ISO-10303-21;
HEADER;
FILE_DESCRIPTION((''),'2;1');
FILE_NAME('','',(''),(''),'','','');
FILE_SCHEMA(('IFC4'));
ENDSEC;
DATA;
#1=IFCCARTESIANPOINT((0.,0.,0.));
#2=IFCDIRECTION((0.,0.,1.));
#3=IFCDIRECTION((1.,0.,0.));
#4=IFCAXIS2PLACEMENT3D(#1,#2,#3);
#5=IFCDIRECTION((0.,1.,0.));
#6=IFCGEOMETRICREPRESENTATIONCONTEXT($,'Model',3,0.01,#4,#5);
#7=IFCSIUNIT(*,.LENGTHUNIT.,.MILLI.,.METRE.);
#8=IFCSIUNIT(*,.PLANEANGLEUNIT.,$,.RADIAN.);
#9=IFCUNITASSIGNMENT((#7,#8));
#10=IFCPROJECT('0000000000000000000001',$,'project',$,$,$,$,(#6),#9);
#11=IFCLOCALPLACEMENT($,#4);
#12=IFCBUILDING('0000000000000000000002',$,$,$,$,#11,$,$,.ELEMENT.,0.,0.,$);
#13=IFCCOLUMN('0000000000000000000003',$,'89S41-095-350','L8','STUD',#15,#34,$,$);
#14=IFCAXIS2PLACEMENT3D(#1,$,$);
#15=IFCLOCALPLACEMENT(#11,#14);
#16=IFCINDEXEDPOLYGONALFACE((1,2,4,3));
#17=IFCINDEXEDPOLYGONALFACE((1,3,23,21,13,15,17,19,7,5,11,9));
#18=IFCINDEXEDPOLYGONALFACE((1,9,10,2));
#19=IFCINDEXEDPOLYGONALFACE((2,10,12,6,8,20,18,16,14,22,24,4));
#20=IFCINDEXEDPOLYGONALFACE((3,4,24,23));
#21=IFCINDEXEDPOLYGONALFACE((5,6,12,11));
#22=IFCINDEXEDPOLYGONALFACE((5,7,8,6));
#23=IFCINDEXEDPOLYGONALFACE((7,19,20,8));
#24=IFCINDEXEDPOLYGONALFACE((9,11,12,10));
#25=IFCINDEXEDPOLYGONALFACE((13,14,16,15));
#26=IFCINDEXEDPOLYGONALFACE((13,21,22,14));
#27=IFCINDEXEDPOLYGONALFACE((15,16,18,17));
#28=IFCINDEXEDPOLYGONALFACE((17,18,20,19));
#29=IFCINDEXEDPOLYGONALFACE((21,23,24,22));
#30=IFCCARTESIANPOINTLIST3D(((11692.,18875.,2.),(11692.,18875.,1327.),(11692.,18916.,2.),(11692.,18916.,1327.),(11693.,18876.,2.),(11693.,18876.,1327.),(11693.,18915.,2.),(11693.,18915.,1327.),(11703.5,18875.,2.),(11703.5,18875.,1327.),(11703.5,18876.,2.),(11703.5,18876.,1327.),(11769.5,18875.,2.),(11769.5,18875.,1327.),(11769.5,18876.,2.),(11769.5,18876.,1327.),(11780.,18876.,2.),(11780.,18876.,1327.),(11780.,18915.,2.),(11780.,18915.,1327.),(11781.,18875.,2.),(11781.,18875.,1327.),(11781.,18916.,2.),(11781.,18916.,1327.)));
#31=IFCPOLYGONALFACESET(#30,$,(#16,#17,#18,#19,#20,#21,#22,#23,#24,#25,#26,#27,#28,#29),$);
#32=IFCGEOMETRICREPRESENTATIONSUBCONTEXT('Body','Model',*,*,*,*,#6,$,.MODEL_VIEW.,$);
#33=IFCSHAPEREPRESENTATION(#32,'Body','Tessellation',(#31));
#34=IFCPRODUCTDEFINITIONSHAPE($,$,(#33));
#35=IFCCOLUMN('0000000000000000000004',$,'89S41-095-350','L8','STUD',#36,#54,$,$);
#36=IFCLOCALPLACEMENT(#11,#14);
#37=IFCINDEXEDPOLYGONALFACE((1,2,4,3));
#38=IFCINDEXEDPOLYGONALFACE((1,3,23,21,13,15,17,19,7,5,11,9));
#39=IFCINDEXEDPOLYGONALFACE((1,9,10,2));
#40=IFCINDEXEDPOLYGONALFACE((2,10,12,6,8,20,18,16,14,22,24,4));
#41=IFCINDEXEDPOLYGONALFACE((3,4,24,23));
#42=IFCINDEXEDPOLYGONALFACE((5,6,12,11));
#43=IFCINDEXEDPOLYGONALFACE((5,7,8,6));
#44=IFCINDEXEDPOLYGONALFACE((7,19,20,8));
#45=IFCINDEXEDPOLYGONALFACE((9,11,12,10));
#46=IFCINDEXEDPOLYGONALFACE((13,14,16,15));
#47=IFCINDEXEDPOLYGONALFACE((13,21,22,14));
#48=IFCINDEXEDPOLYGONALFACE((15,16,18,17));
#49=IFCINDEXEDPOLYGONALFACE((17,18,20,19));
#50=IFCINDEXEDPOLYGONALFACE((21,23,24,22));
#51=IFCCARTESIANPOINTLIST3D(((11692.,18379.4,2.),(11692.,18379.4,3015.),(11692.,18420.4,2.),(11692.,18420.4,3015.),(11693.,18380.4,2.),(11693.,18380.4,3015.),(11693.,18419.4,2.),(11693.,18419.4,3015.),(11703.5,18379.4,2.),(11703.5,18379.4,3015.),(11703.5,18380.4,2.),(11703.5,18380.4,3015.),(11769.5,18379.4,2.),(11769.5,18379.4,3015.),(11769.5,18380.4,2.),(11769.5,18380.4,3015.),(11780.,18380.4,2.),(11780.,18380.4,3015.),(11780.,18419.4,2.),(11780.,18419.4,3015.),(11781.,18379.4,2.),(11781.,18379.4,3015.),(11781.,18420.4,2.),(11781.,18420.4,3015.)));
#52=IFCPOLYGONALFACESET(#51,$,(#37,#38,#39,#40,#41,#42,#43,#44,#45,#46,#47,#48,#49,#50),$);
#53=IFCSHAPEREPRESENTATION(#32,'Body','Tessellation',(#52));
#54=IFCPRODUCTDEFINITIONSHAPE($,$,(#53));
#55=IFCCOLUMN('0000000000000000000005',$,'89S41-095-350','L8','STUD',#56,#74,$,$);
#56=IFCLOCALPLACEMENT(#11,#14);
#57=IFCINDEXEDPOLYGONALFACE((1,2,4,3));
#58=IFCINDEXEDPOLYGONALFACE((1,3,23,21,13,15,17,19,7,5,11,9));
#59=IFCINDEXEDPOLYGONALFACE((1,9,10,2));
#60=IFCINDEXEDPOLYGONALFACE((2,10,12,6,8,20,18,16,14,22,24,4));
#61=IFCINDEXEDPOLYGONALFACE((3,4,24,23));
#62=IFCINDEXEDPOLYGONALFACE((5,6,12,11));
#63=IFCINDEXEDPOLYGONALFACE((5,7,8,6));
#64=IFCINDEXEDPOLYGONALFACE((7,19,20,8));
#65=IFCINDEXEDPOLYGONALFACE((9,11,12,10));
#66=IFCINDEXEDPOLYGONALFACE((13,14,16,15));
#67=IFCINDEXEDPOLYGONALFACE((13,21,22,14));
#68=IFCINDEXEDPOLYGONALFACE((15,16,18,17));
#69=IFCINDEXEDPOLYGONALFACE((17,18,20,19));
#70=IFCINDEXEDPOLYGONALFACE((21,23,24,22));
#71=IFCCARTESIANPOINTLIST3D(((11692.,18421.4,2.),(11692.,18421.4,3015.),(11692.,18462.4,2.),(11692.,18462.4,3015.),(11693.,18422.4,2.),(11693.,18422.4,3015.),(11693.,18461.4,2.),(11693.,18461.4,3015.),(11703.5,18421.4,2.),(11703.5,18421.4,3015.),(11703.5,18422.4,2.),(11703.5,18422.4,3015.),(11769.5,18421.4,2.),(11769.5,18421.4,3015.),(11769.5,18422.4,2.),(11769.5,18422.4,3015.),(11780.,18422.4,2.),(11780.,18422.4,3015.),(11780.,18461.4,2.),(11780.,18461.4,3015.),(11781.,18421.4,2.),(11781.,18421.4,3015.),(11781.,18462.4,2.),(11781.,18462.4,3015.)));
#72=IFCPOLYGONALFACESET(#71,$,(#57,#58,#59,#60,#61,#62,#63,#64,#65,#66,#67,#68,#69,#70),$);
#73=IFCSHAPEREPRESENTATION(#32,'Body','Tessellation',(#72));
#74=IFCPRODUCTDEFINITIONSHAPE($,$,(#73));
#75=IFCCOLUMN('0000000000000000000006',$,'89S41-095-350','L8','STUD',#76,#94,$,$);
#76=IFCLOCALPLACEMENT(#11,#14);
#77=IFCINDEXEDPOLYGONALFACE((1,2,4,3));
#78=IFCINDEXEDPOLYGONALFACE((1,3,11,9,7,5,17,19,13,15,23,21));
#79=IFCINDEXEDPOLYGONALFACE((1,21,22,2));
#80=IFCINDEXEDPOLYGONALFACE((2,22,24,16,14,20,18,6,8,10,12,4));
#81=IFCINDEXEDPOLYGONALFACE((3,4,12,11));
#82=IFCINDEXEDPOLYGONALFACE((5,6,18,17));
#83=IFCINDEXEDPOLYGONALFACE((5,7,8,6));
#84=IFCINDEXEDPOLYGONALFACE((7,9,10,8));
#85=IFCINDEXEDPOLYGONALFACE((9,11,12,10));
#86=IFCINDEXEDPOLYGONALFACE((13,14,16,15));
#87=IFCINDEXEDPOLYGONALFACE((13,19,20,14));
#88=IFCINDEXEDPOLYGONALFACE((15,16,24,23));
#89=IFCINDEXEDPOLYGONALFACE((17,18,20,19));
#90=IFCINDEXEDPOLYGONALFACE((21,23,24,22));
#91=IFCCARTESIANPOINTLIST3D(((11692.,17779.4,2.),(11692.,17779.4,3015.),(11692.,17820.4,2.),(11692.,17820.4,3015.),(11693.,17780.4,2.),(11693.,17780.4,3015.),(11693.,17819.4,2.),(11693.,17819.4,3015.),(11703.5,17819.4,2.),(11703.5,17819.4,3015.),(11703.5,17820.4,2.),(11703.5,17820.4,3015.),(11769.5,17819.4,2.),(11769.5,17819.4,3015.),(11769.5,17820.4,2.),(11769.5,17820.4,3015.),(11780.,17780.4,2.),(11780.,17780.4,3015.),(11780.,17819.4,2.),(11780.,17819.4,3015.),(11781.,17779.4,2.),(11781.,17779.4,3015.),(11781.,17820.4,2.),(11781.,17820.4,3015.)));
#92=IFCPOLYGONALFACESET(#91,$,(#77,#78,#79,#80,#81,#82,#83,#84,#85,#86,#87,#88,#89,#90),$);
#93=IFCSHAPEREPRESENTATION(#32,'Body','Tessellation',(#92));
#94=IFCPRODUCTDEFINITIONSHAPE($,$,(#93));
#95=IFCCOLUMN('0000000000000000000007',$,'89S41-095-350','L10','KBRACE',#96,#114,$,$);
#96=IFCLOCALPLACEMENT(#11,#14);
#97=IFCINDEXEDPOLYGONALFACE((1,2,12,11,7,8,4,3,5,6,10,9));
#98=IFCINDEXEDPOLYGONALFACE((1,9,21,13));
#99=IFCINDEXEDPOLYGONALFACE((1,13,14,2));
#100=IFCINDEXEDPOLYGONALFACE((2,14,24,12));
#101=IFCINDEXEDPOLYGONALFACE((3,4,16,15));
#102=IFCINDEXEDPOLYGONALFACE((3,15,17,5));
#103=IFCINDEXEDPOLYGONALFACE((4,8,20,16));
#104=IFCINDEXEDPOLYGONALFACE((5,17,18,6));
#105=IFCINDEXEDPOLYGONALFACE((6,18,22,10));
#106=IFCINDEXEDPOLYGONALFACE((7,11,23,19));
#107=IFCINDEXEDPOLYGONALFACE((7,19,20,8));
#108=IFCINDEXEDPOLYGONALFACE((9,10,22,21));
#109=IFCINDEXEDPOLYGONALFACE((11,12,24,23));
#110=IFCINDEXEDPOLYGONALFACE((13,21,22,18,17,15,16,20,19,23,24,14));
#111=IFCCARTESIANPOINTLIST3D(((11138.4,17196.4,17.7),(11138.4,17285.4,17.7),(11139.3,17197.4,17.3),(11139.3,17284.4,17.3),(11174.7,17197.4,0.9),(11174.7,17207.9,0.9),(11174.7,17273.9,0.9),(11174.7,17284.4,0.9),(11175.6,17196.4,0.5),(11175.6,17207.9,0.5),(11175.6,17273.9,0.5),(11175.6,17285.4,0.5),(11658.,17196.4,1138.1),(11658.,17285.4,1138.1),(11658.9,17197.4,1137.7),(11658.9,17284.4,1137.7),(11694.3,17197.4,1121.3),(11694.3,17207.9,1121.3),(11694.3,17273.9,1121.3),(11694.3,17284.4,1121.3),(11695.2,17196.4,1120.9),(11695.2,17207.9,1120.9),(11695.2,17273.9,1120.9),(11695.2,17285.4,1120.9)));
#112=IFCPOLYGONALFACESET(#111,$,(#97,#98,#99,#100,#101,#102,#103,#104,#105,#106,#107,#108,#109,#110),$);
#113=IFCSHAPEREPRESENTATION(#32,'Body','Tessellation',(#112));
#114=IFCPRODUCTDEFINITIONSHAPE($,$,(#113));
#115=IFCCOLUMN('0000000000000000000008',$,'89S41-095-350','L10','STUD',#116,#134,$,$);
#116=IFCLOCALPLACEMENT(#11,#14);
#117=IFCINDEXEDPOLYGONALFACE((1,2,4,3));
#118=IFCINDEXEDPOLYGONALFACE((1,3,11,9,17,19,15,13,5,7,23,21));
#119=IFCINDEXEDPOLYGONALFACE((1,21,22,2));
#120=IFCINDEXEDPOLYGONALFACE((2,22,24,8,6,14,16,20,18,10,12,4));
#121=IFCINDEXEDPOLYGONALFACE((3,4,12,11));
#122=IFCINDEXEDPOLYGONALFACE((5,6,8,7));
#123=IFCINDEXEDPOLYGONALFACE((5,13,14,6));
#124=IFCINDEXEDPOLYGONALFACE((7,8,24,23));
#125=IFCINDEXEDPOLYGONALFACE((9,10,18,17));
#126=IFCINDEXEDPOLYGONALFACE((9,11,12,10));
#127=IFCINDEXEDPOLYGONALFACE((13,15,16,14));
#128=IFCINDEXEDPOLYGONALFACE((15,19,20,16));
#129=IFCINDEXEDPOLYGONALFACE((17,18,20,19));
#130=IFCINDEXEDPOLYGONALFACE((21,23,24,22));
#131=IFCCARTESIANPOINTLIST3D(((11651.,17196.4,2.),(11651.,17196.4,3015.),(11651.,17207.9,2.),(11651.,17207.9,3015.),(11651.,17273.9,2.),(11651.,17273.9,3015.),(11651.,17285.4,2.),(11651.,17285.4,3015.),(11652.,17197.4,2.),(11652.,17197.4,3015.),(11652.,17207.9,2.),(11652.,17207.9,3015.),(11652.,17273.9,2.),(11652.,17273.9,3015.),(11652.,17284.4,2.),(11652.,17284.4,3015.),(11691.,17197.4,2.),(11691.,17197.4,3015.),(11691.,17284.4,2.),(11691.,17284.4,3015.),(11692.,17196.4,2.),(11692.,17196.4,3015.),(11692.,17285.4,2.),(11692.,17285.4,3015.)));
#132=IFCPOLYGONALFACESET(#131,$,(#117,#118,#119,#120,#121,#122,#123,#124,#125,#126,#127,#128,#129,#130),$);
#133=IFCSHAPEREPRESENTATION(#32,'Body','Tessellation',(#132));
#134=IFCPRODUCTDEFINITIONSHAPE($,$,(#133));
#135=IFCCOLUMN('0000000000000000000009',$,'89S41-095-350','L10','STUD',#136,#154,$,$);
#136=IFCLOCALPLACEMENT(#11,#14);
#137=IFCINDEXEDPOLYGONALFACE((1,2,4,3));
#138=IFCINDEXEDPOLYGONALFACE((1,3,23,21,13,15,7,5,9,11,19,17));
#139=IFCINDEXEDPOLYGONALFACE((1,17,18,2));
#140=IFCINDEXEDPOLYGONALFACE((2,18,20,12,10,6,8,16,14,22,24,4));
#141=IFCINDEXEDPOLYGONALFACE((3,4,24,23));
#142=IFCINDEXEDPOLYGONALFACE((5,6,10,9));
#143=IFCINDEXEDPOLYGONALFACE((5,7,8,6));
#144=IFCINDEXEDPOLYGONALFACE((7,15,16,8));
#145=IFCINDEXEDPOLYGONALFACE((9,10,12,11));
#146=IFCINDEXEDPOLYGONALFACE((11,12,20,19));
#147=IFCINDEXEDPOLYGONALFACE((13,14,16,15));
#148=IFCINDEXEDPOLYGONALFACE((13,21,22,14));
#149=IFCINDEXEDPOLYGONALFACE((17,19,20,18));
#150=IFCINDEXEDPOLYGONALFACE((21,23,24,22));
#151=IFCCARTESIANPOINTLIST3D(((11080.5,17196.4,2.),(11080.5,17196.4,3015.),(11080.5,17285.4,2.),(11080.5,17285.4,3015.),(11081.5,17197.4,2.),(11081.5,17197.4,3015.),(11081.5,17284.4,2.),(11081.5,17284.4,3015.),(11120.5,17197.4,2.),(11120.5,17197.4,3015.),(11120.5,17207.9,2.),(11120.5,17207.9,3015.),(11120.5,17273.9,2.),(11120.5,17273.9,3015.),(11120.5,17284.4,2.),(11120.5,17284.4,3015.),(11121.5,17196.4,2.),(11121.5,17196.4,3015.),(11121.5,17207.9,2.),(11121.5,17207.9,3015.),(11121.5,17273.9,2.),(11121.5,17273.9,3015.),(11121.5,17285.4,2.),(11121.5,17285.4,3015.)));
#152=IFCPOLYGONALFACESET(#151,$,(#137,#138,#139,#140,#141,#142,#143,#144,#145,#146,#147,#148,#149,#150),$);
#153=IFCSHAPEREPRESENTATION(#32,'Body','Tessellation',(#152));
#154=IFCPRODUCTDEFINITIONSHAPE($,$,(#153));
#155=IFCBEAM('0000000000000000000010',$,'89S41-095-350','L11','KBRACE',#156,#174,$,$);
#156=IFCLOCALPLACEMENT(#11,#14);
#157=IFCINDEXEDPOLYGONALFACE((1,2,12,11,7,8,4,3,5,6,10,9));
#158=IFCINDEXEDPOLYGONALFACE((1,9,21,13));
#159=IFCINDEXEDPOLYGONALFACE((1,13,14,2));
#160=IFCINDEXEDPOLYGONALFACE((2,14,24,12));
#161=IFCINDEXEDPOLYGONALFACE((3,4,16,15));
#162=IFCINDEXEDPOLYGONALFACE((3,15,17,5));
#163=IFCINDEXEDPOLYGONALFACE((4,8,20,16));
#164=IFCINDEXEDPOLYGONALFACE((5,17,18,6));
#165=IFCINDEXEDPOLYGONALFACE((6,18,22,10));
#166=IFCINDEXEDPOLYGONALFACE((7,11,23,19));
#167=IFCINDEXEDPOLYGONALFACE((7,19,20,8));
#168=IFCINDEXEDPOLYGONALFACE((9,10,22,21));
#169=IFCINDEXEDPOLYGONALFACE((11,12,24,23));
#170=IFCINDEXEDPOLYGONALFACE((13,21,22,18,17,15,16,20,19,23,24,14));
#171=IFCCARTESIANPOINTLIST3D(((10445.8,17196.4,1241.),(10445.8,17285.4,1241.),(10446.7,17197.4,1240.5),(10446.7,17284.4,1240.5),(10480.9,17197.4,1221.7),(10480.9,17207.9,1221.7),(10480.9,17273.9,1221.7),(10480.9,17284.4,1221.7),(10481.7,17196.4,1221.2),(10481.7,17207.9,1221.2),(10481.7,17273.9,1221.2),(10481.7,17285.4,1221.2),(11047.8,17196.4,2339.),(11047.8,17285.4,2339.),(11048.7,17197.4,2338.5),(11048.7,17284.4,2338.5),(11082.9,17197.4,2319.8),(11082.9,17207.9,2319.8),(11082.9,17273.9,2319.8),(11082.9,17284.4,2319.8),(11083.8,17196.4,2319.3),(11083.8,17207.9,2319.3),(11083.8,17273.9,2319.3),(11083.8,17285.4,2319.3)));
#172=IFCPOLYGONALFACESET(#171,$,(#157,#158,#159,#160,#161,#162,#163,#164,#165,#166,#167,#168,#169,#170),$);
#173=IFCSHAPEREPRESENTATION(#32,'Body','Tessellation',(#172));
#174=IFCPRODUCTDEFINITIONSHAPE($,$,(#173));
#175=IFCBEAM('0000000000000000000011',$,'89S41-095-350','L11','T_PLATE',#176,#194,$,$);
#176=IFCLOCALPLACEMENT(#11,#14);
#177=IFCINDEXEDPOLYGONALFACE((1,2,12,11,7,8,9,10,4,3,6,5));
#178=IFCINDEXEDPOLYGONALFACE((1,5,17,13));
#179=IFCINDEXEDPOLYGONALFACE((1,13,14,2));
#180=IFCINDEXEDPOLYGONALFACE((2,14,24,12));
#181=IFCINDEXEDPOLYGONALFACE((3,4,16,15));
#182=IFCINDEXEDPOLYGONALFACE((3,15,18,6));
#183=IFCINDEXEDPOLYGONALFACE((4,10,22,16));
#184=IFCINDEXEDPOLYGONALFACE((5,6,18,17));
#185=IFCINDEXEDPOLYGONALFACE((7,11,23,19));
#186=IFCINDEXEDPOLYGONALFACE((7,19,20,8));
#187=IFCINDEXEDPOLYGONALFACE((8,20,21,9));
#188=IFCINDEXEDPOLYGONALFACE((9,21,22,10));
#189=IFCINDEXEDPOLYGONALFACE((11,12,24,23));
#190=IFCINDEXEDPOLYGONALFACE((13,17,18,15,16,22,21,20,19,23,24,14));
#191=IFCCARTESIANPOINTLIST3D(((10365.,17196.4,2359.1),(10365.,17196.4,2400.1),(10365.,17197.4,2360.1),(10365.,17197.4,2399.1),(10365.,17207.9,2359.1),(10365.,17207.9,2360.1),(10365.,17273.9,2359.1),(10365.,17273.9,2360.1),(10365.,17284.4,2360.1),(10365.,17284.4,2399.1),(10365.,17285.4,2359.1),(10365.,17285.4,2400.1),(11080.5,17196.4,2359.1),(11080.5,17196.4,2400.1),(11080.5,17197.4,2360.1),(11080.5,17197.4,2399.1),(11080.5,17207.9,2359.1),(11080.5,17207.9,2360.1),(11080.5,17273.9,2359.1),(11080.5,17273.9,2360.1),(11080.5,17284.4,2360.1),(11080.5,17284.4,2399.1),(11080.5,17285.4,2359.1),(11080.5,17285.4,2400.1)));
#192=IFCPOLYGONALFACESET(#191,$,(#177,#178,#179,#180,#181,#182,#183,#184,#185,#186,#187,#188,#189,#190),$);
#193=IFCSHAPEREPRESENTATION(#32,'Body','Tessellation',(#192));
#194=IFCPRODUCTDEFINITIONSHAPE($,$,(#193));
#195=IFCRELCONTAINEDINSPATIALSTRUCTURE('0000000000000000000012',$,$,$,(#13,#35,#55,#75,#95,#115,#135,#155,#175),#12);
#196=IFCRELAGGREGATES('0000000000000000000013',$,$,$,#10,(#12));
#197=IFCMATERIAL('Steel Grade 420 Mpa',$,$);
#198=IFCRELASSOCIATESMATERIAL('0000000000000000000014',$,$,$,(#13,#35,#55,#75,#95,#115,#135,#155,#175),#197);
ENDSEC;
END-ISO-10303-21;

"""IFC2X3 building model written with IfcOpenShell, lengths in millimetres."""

from ifc_helpers import new_model, si_unit, direction, frame, origin, origin_with_axes, origin_2d_with_axis, place, context, subcontext, project, spatial, c_section, extrude, source, transform, mapped, material, element, save


model = new_model("IFC2X3")

# Units and contexts
model_context = context("Model", 3, precision=0.01, world=origin_with_axes(), true_north=direction((0.0, 1.0, 0.0)))
body_context = subcontext(model_context, "Body", "Model", "MODEL_VIEW")
ifc_project = project(units=[si_unit("LENGTHUNIT", "METRE", prefix="MILLI"), si_unit("PLANEANGLEUNIT", "RADIAN")], contexts=[model_context])

# Building
building_placement = place(None, origin_with_axes())
building = spatial("IfcBuilding", under=ifc_project, at=building_placement, CompositionType="ELEMENT", ElevationOfRefHeight=0.0, ElevationOfTerrain=0.0)

# Columns
ifc_material = material(Name="Steel Grade 420 Mpa")
shared_shape_1 = source(origin(), body_context, "Body", "SweptSolid", [
    extrude(c_section(Depth=89.0, Width=41.0, WallThickness=1.0, Girth=11.5, at=origin_2d_with_axis()), origin_with_axes(), (0.0, 0.0, 1.0), 1325.0),
])
column_1_placement = place(None, frame((11736.5, 18895.5, 2.0), z_axis=(0.0, 0.0, 1.0), x_axis=(0.0, -1.0, 0.0)))
element("IfcColumn", 1, at=column_1_placement, inside=building, material=ifc_material, Name="89S41-095-350", Description="L8", ObjectType="STUD", context=body_context, shape_type="MappedRepresentation", body=[
    mapped(shared_shape_1, transform((0.0, 0.0, 0.0), scale=1.0)),
])
shared_shape_2 = source(origin(), body_context, "Body", "SweptSolid", [
    extrude(c_section(Depth=89.0, Width=41.0, WallThickness=1.0, Girth=11.5, at=origin_2d_with_axis()), origin_with_axes(), (0.0, 0.0, 1.0), 3013.0),
])
column_2_placement = place(None, frame((11736.5, 18399.9, 2.0), z_axis=(0.0, 0.0, 1.0), x_axis=(0.0, -1.0, 0.0)))
element("IfcColumn", 2, at=column_2_placement, inside=building, material=ifc_material, Name="89S41-095-350", Description="L8", ObjectType="STUD", context=body_context, shape_type="MappedRepresentation", body=[
    mapped(shared_shape_2, transform((0.0, 0.0, 0.0), scale=1.0)),
])
shared_shape_3 = source(origin(), body_context, "Body", "SweptSolid", [
    extrude(c_section(Depth=89.0, Width=41.0, WallThickness=1.0, Girth=11.5, at=origin_2d_with_axis()), origin_with_axes(), (0.0, 0.0, 1.0), 3013.0),
])
column_3_placement = place(None, frame((11736.5, 18441.9, 2.0), z_axis=(0.0, 0.0, 1.0), x_axis=(0.0, -1.0, 0.0)))
element("IfcColumn", 3, at=column_3_placement, inside=building, material=ifc_material, Name="89S41-095-350", Description="L8", ObjectType="STUD", context=body_context, shape_type="MappedRepresentation", body=[
    mapped(shared_shape_3, transform((0.0, 0.0, 0.0), scale=1.0)),
])
shared_shape_4 = source(origin(), body_context, "Body", "SweptSolid", [
    extrude(c_section(Depth=89.0, Width=41.0, WallThickness=1.0, Girth=11.5, at=origin_2d_with_axis()), origin_with_axes(), (0.0, 0.0, 1.0), 3013.0),
])
column_4_placement = place(None, frame((11736.5, 17799.9, 2.0), z_axis=(0.0, 0.0, 1.0), x_axis=(0.0, 1.0, 0.0)))
element("IfcColumn", 4, at=column_4_placement, inside=building, material=ifc_material, Name="89S41-095-350", Description="L8", ObjectType="STUD", context=body_context, shape_type="MappedRepresentation", body=[
    mapped(shared_shape_4, transform((0.0, 0.0, 0.0), scale=1.0)),
])
shared_shape_5 = source(origin(), body_context, "Body", "SweptSolid", [
    extrude(c_section(Depth=89.0, Width=41.0, WallThickness=1.0, Girth=11.5, at=origin_2d_with_axis()), origin_with_axes(), (0.0, 0.0, 1.0), 1235.0),
])
column_5_placement = place(None, frame((11157.0, 17240.9, 9.1), z_axis=(0.420698, 0.0, 0.907201), x_axis=(0.907201, 0.0, -0.420698)))
element("IfcColumn", 5, at=column_5_placement, inside=building, material=ifc_material, Name="89S41-095-350", Description="L10", ObjectType="KBRACE", context=body_context, shape_type="MappedRepresentation", body=[
    mapped(shared_shape_5, transform((0.0, 0.0, 0.0), scale=1.0)),
])
shared_shape_6 = source(origin(), body_context, "Body", "SweptSolid", [
    extrude(c_section(Depth=89.0, Width=41.0, WallThickness=1.0, Girth=11.5, at=origin_2d_with_axis()), origin_with_axes(), (0.0, 0.0, 1.0), 3013.0),
])
column_6_placement = place(None, frame((11671.5, 17240.9, 2.0), z_axis=(0.0, 0.0, 1.0), x_axis=(-1.0, 0.0, 0.0)))
element("IfcColumn", 6, at=column_6_placement, inside=building, material=ifc_material, Name="89S41-095-350", Description="L10", ObjectType="STUD", context=body_context, shape_type="MappedRepresentation", body=[
    mapped(shared_shape_6, transform((0.0, 0.0, 0.0), scale=1.0)),
])
shared_shape_7 = source(origin(), body_context, "Body", "SweptSolid", [
    extrude(c_section(Depth=89.0, Width=41.0, WallThickness=1.0, Girth=11.5, at=origin_2d_with_axis()), origin_with_axes(), (0.0, 0.0, 1.0), 3013.0),
])
column_7_placement = place(None, frame((11101.0, 17240.9, 2.0), z_axis=(0.0, 0.0, 1.0), x_axis=(1.0, 0.0, 0.0)))
element("IfcColumn", 7, at=column_7_placement, inside=building, material=ifc_material, Name="89S41-095-350", Description="L10", ObjectType="STUD", context=body_context, shape_type="MappedRepresentation", body=[
    mapped(shared_shape_7, transform((0.0, 0.0, 0.0), scale=1.0)),
])

# Beams
shared_shape_8 = source(origin(), body_context, "Body", "SweptSolid", [
    extrude(c_section(Depth=89.0, Width=41.0, WallThickness=1.0, Girth=11.5, at=origin_2d_with_axis()), origin_with_axes(), (0.0, 0.0, 1.0), 1252.3),
])
beam_1_placement = place(None, frame((10463.8, 17240.9, 1231.1), z_axis=(0.480762, 0.0, 0.876851), x_axis=(0.876851, 0.0, -0.480762)))
element("IfcBeam", 8, at=beam_1_placement, inside=building, material=ifc_material, Name="89S41-095-350", Description="L11", ObjectType="KBRACE", context=body_context, shape_type="MappedRepresentation", body=[
    mapped(shared_shape_8, transform((0.0, 0.0, 0.0), scale=1.0)),
])
shared_shape_9 = source(origin(), body_context, "Body", "SweptSolid", [
    extrude(c_section(Depth=89.0, Width=41.0, WallThickness=1.0, Girth=11.5, at=origin_2d_with_axis()), origin_with_axes(), (0.0, 0.0, 1.0), 715.5),
])
beam_2_placement = place(None, frame((10365.0, 17240.9, 2379.6), z_axis=(1.0, 0.0, 0.0), x_axis=(0.0, 0.0, -1.0)))
element("IfcBeam", 9, at=beam_2_placement, inside=building, material=ifc_material, Name="89S41-095-350", Description="L11", ObjectType="T_PLATE", context=body_context, shape_type="MappedRepresentation", body=[
    mapped(shared_shape_9, transform((0.0, 0.0, 0.0), scale=1.0)),
])

save(model, "model.ifc")
